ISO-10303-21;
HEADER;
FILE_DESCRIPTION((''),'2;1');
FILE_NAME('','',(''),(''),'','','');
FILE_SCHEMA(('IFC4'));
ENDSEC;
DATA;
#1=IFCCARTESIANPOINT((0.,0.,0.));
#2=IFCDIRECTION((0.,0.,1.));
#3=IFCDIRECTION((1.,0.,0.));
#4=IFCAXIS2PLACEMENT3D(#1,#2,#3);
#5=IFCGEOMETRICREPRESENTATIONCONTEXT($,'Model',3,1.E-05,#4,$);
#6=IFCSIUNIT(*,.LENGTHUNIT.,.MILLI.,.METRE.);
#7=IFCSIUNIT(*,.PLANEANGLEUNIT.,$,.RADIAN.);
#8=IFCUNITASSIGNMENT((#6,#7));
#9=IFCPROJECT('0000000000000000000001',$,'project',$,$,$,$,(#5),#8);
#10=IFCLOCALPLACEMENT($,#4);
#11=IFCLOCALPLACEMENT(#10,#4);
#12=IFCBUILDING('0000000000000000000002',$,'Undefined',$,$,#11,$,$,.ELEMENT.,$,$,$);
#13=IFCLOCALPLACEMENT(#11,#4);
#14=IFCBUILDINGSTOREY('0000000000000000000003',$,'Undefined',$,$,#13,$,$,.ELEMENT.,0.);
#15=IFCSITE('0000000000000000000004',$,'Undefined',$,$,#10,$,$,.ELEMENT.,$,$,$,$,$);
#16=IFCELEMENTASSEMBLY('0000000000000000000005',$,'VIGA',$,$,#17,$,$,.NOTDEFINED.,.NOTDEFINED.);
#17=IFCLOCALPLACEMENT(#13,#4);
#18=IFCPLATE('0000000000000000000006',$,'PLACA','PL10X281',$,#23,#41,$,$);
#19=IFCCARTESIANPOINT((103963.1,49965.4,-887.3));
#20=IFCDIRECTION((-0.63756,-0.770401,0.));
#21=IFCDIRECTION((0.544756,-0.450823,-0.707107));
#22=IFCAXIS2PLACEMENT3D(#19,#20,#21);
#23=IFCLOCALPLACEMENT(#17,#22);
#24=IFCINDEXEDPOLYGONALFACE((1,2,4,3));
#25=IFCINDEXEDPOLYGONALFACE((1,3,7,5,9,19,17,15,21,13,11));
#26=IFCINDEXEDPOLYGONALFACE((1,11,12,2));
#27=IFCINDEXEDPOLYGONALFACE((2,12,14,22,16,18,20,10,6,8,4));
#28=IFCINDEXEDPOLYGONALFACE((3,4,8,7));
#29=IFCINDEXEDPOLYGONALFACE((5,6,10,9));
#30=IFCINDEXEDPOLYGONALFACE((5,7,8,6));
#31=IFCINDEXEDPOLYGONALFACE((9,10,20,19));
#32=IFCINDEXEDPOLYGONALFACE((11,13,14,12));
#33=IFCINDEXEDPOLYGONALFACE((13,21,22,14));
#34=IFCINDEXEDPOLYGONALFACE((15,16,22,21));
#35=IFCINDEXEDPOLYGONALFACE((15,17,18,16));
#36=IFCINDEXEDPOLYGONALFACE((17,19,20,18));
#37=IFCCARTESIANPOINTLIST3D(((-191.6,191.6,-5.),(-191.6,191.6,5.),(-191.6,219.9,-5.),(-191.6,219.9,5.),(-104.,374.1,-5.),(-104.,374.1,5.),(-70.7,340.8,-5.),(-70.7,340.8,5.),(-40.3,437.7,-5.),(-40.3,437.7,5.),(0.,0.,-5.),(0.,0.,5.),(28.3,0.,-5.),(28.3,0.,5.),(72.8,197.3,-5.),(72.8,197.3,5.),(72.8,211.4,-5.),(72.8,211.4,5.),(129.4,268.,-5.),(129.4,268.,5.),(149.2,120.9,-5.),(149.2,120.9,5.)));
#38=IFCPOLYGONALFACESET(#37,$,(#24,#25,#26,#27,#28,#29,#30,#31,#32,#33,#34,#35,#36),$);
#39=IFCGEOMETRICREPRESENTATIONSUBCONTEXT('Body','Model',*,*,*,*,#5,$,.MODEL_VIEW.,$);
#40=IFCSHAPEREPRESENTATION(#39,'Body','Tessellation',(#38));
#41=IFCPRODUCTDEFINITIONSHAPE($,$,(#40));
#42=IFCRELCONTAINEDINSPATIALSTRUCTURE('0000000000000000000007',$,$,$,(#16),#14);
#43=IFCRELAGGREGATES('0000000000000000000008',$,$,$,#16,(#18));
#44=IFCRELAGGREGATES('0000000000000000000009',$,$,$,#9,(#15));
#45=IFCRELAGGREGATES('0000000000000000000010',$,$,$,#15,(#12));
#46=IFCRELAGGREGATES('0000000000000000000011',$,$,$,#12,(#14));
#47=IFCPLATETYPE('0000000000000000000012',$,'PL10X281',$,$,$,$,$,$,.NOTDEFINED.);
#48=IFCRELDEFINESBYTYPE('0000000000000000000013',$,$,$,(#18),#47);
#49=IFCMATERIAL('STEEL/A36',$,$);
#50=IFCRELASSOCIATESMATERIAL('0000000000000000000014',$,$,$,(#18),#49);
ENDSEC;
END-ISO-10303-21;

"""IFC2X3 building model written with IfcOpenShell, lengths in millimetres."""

from ifc_helpers import new_model, si_unit, frame, origin_with_axes, place, context, subcontext, project, spatial, polyline, outline, extrude, material, type_object, element, aggregate, save


model = new_model("IFC2X3")

# Units and contexts
model_context = context("Model", 3, precision=1e-05, world=origin_with_axes())
body_context = subcontext(model_context, "Body", "Model", "MODEL_VIEW")
ifc_project = project(units=[si_unit("LENGTHUNIT", "METRE", prefix="MILLI"), si_unit("PLANEANGLEUNIT", "RADIAN")], contexts=[model_context])

# Site, building, storey
site_placement = place(None, origin_with_axes())
site = spatial("IfcSite", under=ifc_project, at=site_placement, Name="Undefined", CompositionType="ELEMENT")
building_placement = place(site_placement, origin_with_axes())
building = spatial("IfcBuilding", under=site, at=building_placement, Name="Undefined", CompositionType="ELEMENT")
storey_placement = place(building_placement, origin_with_axes())
storey = spatial("IfcBuildingStorey", under=building, at=storey_placement, Name="Undefined", CompositionType="ELEMENT", Elevation=0.0)

# Element assembly
assembly_1_placement = place(storey_placement, origin_with_axes())
assembly_1 = element("IfcElementAssembly", 1, at=assembly_1_placement, inside=storey, Name="VIGA", AssemblyPlace="NOTDEFINED", PredefinedType="NOTDEFINED")
ifc_material_1 = material(Name="STEEL/A36")

# Plate
plate_type_1 = type_object("IfcPlateType", Name="PL10X281", PredefinedType="NOTDEFINED")
plate_1_placement = place(assembly_1_placement, frame((103963.1, 49965.4, -887.3), z_axis=(-0.63756, -0.770401, 0.0), x_axis=(0.544756, -0.450823, -0.707107)))
plate_1 = element("IfcPlate", 2, at=plate_1_placement, type_object=plate_type_1, material=ifc_material_1, Name="PLACA", Description="PL10X281", context=body_context, shape_type="SweptSolid", body=[
    extrude(outline(polyline([(0.0, 0.0), (28.3, 0.0), (149.2, 120.9), (72.8, 197.3), (72.8, 211.4), (129.4, 268.0), (-40.3, 437.7), (-104.0, 374.1), (-70.7, 340.8), (-191.6, 219.9), (-191.6, 191.6), (0.0, 0.0)])), frame((0.0, 0.0, -5.0), z_axis=(0.0, 0.0, 1.0), x_axis=(1.0, 0.0, 0.0)), (0.0, 0.0, 1.0), 10.0),
])
aggregate(assembly_1, [plate_1])

save(model, "model.ifc")
